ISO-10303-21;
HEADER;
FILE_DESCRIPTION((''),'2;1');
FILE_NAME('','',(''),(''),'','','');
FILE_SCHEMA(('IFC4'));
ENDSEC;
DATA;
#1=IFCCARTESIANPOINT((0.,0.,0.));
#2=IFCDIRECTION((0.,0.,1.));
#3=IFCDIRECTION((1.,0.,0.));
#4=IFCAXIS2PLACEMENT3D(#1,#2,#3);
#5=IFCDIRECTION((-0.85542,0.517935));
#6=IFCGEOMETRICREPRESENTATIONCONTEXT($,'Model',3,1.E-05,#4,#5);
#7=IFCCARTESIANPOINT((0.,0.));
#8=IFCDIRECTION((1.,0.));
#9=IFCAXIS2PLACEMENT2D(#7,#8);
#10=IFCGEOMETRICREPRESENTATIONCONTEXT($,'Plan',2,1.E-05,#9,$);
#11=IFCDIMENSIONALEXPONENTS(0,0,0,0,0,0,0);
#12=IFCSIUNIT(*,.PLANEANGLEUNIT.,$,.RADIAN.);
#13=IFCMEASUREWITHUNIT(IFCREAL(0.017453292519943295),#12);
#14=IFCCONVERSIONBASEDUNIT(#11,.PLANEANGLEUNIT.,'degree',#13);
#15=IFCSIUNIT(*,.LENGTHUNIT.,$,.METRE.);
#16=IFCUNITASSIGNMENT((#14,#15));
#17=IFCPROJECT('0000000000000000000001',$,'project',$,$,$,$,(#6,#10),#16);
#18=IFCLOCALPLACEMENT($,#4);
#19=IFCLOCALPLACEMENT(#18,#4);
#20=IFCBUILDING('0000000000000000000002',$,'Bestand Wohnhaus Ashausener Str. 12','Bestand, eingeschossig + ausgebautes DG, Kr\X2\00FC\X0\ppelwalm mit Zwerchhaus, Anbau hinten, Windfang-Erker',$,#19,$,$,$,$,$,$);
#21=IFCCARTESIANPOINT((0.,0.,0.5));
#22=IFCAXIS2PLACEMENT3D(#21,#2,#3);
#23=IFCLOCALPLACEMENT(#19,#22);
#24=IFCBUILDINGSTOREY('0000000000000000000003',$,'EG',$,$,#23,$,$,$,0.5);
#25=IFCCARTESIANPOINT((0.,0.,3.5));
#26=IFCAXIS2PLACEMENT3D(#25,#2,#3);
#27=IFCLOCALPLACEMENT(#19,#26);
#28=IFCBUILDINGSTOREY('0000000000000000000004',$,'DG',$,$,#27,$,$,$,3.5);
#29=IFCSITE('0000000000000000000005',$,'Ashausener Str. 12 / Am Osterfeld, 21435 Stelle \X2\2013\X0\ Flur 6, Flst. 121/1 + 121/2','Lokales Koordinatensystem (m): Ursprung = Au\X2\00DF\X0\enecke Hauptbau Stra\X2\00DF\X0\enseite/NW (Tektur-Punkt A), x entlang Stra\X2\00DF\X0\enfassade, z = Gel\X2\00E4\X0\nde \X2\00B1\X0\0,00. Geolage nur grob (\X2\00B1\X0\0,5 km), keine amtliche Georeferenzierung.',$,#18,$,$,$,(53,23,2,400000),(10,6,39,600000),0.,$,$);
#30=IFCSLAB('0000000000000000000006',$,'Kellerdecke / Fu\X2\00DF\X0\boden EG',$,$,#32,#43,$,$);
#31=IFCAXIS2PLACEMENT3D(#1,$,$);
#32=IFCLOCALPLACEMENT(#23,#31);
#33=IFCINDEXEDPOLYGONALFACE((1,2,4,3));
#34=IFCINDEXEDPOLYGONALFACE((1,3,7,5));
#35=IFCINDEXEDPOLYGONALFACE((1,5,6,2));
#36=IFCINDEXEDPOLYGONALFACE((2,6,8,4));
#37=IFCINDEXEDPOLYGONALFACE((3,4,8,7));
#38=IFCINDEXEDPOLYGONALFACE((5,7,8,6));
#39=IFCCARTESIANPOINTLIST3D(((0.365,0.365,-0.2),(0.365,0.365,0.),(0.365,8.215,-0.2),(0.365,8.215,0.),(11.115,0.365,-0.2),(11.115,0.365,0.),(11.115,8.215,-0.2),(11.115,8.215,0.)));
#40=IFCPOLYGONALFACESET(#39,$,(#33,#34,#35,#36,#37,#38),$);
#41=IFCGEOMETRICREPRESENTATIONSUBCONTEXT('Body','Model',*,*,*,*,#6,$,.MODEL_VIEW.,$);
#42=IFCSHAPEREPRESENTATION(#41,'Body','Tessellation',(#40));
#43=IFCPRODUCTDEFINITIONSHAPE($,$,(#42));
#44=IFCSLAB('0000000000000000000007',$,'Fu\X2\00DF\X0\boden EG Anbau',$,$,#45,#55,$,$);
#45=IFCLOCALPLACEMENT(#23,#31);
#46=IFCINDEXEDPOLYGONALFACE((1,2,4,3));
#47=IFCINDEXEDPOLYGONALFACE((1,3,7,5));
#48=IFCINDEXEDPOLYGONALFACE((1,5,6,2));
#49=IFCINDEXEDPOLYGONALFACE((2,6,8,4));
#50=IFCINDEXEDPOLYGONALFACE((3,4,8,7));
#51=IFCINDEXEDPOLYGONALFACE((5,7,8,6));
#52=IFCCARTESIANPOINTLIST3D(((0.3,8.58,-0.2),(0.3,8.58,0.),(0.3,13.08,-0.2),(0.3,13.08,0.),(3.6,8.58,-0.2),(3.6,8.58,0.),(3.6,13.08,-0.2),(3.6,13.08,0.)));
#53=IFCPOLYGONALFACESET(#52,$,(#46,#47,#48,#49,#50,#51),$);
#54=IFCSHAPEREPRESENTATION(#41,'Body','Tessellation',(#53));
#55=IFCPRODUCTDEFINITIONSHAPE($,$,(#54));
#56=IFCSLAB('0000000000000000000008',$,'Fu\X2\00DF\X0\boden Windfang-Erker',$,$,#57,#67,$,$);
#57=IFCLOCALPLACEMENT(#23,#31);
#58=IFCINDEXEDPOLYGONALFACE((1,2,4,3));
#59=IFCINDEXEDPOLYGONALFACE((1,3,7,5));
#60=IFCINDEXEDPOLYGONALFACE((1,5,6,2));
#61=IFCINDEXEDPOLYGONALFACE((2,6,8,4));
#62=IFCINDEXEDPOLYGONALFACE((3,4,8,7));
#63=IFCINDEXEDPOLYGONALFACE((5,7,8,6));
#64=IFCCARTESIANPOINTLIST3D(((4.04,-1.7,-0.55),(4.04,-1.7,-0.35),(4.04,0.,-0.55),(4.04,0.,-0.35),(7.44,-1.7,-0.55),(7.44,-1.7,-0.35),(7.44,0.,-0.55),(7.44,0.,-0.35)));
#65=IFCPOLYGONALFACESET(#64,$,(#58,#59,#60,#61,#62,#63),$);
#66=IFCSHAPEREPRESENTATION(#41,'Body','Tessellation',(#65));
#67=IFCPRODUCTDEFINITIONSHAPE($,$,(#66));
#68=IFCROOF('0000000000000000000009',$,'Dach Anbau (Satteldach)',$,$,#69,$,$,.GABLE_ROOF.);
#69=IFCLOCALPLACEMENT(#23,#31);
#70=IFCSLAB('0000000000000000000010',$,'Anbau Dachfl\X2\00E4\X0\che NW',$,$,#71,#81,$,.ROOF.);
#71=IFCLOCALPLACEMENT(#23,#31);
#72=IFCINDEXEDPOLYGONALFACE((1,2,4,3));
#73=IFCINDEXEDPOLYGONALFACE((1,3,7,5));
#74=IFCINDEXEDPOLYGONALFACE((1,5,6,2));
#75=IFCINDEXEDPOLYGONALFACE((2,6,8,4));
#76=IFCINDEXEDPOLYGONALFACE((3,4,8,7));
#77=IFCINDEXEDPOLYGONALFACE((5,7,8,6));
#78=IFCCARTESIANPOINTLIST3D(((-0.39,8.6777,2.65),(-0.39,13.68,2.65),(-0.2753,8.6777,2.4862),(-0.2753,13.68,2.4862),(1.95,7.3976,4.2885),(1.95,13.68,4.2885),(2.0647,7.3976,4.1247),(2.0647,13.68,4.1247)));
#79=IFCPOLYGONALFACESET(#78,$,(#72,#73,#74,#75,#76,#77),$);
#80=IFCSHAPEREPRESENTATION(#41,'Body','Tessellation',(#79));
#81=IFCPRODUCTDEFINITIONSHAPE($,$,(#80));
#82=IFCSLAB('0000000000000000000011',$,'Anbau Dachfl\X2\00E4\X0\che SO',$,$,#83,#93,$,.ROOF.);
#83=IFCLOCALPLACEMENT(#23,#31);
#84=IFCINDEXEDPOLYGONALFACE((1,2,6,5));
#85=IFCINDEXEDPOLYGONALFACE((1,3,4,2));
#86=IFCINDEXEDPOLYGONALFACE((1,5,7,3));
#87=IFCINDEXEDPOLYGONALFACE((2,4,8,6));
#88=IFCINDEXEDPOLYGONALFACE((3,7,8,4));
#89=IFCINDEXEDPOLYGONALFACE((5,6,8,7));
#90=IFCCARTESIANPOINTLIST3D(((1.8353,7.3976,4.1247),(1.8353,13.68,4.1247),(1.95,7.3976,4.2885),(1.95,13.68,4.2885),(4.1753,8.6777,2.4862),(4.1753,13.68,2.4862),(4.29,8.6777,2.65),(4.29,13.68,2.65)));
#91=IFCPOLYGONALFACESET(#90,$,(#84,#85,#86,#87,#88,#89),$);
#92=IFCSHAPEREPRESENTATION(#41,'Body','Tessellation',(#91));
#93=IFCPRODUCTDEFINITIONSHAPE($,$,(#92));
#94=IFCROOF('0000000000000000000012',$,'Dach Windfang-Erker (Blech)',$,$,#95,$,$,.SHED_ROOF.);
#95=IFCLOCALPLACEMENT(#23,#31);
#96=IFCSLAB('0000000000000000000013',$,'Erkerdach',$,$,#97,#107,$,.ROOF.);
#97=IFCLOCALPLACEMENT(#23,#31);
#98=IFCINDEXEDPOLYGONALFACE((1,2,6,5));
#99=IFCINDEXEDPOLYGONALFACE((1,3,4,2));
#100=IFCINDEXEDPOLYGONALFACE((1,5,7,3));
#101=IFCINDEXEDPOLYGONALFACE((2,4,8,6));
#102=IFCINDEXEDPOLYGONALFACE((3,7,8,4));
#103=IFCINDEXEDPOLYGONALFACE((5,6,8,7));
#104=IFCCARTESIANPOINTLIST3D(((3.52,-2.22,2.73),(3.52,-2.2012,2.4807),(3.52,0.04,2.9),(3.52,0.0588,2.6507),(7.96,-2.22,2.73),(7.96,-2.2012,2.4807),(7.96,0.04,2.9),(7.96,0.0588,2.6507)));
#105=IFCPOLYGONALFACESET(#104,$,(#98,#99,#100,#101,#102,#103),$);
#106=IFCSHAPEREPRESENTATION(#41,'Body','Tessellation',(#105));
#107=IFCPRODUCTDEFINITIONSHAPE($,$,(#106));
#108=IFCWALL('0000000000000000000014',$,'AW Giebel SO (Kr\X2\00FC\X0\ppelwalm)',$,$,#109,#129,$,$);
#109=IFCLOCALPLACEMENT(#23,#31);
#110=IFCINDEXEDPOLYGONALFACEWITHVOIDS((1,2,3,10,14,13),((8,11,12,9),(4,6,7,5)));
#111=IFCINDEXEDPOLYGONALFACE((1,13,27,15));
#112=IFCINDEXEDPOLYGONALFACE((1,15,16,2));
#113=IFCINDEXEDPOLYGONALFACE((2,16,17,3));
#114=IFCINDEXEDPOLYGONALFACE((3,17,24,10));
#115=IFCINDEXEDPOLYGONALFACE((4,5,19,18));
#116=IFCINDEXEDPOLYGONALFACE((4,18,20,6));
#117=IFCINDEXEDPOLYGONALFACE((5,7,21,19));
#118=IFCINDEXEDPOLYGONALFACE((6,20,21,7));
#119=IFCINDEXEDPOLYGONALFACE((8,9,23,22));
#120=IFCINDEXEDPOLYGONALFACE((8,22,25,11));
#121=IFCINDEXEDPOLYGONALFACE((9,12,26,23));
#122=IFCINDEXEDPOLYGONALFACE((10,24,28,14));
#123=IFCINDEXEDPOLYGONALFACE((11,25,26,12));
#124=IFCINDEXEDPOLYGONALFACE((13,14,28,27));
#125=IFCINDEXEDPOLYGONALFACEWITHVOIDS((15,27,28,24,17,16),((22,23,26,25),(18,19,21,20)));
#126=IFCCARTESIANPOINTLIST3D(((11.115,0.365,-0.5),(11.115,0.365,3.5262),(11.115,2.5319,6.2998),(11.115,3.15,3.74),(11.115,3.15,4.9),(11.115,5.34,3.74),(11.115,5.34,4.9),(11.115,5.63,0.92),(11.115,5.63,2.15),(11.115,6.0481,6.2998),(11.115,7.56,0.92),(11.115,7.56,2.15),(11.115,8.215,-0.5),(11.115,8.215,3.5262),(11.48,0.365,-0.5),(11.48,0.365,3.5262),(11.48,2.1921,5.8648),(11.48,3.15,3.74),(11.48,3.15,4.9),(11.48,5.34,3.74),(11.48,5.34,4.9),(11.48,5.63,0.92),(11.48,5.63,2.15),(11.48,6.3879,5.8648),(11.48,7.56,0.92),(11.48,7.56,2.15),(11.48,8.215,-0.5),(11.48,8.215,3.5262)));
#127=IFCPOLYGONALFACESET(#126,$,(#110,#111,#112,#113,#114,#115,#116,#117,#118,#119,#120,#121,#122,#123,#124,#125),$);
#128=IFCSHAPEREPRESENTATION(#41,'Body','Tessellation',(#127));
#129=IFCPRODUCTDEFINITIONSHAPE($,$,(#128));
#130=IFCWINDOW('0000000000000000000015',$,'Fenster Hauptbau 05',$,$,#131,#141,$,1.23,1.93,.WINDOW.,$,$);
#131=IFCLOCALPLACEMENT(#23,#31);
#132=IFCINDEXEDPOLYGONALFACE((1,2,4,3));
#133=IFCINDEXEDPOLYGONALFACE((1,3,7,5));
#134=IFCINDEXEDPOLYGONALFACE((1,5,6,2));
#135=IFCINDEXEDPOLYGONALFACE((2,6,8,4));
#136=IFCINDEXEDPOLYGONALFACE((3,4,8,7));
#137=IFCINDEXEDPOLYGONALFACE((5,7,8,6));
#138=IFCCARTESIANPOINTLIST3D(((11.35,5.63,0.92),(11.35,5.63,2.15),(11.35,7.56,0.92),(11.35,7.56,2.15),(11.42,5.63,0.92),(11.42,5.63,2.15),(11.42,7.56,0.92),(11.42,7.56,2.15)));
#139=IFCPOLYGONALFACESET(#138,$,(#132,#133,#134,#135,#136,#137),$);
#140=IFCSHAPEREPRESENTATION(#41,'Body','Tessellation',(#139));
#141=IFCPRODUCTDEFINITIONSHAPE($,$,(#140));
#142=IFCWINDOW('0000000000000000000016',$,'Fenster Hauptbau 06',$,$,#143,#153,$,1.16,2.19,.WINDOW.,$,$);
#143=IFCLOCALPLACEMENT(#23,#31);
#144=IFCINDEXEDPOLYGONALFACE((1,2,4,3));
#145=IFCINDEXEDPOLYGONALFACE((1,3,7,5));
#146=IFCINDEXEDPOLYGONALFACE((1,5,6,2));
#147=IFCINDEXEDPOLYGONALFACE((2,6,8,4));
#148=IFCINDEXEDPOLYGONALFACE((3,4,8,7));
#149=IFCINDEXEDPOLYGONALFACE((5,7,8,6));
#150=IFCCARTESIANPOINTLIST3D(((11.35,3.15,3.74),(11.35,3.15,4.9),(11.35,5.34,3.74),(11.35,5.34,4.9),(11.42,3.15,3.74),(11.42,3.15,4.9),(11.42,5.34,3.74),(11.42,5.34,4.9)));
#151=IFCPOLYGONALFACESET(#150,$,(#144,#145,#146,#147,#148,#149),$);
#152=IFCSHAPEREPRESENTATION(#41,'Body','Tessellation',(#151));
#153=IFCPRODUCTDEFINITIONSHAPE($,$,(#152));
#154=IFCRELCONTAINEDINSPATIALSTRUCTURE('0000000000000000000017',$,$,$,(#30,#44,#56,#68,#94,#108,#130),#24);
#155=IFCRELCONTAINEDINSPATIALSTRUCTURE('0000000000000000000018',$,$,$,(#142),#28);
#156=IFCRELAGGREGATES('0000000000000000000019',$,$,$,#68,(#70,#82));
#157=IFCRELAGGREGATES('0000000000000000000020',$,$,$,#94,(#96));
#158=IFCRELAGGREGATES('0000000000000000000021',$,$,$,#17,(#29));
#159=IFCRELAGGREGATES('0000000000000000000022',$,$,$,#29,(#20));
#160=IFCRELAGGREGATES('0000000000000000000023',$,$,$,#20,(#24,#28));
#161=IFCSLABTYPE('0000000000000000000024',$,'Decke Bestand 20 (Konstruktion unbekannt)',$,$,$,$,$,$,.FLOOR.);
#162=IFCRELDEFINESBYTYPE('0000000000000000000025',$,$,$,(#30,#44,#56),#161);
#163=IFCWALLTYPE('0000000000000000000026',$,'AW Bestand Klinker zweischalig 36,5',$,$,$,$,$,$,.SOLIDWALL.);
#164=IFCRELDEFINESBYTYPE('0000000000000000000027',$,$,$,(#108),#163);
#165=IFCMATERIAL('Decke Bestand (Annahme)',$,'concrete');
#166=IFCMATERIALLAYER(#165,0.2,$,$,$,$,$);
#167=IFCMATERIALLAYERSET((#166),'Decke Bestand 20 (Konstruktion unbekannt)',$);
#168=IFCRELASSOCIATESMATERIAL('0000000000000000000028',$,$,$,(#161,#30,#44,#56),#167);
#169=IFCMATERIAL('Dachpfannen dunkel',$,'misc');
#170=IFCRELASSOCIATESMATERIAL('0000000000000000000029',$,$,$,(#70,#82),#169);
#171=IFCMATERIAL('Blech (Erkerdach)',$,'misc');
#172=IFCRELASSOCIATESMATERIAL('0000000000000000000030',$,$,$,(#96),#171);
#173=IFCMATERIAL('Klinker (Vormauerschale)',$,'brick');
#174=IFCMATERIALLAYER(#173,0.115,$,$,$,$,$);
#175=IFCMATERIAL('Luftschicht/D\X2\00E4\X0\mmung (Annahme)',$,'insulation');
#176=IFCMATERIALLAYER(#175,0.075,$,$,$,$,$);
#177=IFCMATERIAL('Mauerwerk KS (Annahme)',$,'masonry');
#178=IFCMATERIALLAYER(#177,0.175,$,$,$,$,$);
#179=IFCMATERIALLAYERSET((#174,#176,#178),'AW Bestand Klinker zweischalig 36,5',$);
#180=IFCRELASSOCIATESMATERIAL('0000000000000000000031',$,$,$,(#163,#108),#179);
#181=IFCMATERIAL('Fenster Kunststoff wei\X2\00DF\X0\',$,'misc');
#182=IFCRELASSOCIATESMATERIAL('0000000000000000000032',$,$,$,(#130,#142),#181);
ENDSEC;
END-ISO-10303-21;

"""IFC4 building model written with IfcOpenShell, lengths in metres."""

from ifc_helpers import new_model, entity, si_unit, converted_unit, direction, frame, origin_with_axes, origin_2d_with_axis, place, context, subcontext, project, spatial, polyline, indexed_curve, outline, extrude, clip, halfspace, material, layer, layer_set, layer_usage, type_object, element, fill, aggregate, save


model = new_model("IFC4")

# Units and contexts
model_context = context("Model", 3, precision=1e-05, world=origin_with_axes(), true_north=direction((-0.85542, 0.517935)))
plan_context = context("Plan", 2, precision=1e-05, world=origin_2d_with_axis())
body_context = subcontext(model_context, "Body", "Model", "MODEL_VIEW")
ifc_project = project(units=[converted_unit("PLANEANGLEUNIT", "degree", entity("IfcReal", 0.017453292519943295), si_unit("PLANEANGLEUNIT", "RADIAN"), dimensions=[0, 0, 0, 0, 0, 0, 0]), si_unit("LENGTHUNIT", "METRE")], contexts=[model_context, plan_context])

# Site, building, storey
site_placement = place(None, origin_with_axes())
site = spatial("IfcSite", under=ifc_project, at=site_placement, Name="Ashausener Str. 12 / Am Osterfeld, 21435 Stelle – Flur 6, Flst. 121/1 + 121/2", Description="Lokales Koordinatensystem (m): Ursprung = Außenecke Hauptbau Straßenseite/NW (Tektur-Punkt A), x entlang Straßenfassade, z = Gelände ±0,00. Geolage nur grob (±0,5 km), keine amtliche Georeferenzierung.", RefLatitude=(53, 23, 2, 400000), RefLongitude=(10, 6, 39, 600000), RefElevation=0.0)
building_placement = place(site_placement, origin_with_axes())
building = spatial("IfcBuilding", under=site, at=building_placement, Name="Bestand Wohnhaus Ashausener Str. 12", Description="Bestand, eingeschossig + ausgebautes DG, Krüppelwalm mit Zwerchhaus, Anbau hinten, Windfang-Erker")
storey_1_placement = place(building_placement, frame((0.0, 0.0, 0.5), z_axis=(0.0, 0.0, 1.0), x_axis=(1.0, 0.0, 0.0)))
storey_1 = spatial("IfcBuildingStorey", under=building, at=storey_1_placement, Name="EG", Elevation=0.5)

# Slabs
ifc_material_1 = material(Name="Decke Bestand (Annahme)", Category="concrete")
ifc_layer_1 = layer(ifc_material_1, 0.2)
ifc_layer_set_1 = layer_set([ifc_layer_1], Name="Decke Bestand 20 (Konstruktion unbekannt)")
ifc_layer_usage_1 = layer_usage(ifc_layer_set_1, "AXIS3", "POSITIVE", 0.0)
slab_type = type_object("IfcSlabType", Name="Decke Bestand 20 (Konstruktion unbekannt)", PredefinedType="FLOOR", material=ifc_layer_set_1)
slab_1_placement = place(storey_1_placement, frame((0.0, 0.0, -0.5), z_axis=(0.0, 0.0, 1.0), x_axis=(1.0, 0.0, 0.0)))
element("IfcSlab", 1, at=slab_1_placement, inside=storey_1, type_object=slab_type, material=ifc_layer_usage_1, Name="Kellerdecke / Fußboden EG", context=body_context, shape_type="SweptSolid", body=[
    extrude(outline(polyline([(0.365, 0.365), (11.115, 0.365), (11.115, 8.215), (0.365, 8.215), (0.365, 0.365)])), frame((0.0, 0.0, 0.3)), (0.0, 0.0, 1.0), 0.2),
])
ifc_layer_usage_2 = layer_usage(ifc_layer_set_1, "AXIS3", "POSITIVE", 0.0)
slab_2_placement = place(storey_1_placement, frame((0.0, 0.0, -0.5), z_axis=(0.0, 0.0, 1.0), x_axis=(1.0, 0.0, 0.0)))
element("IfcSlab", 2, at=slab_2_placement, inside=storey_1, type_object=slab_type, material=ifc_layer_usage_2, Name="Fußboden EG Anbau", context=body_context, shape_type="SweptSolid", body=[
    extrude(outline(polyline([(0.3, 8.58), (3.6, 8.58), (3.6, 13.08), (0.3, 13.08), (0.3, 8.58)])), frame((0.0, 0.0, 0.3)), (0.0, 0.0, 1.0), 0.2),
])
ifc_layer_usage_3 = layer_usage(ifc_layer_set_1, "AXIS3", "POSITIVE", 0.0)
slab_3_placement = place(storey_1_placement, frame((0.0, 0.0, -0.5), z_axis=(0.0, 0.0, 1.0), x_axis=(1.0, 0.0, 0.0)))
element("IfcSlab", 3, at=slab_3_placement, inside=storey_1, type_object=slab_type, material=ifc_layer_usage_3, Name="Fußboden Windfang-Erker", context=body_context, shape_type="SweptSolid", body=[
    extrude(outline(polyline([(4.04, -1.7), (7.44, -1.7), (7.44, 0.0), (4.04, 0.0), (4.04, -1.7)])), frame((0.0, 0.0, -0.05)), (0.0, 0.0, 1.0), 0.2),
])

# Roof, slabs
roof_1_placement = place(storey_1_placement, frame((0.0, 0.0, -0.5), z_axis=(0.0, 0.0, 1.0), x_axis=(1.0, 0.0, 0.0)))
roof_1 = element("IfcRoof", 4, at=roof_1_placement, inside=storey_1, Name="Dach Anbau (Satteldach)", PredefinedType="GABLE_ROOF")
ifc_material_2 = material(Name="Dachpfannen dunkel", Category="misc")
slab_4_placement = place(roof_1_placement, origin_with_axes())
slab_4 = element("IfcSlab", 5, at=slab_4_placement, material=ifc_material_2, Name="Anbau Dachfläche NW", PredefinedType="ROOF", context=body_context, shape_type="SweptSolid", body=[
    extrude(outline(polyline([(0.0, 0.0), (2.8566, 0.0), (2.8566, -6.2824), (0.0, -5.0023), (0.0, 0.0)])), frame((-0.39, 13.68, 3.15), z_axis=(-0.573577, 0.0, 0.819151), x_axis=(0.819151, 0.0, 0.573577)), (0.0, 0.0, -1.0), 0.2),
])
slab_5_placement = place(roof_1_placement, origin_with_axes())
slab_5 = element("IfcSlab", 6, at=slab_5_placement, material=ifc_material_2, Name="Anbau Dachfläche SO", PredefinedType="ROOF", context=body_context, shape_type="SweptSolid", body=[
    extrude(outline(polyline([(0.0, 0.0), (2.8566, 0.0), (2.8566, -5.0023), (0.0, -6.2824), (0.0, 0.0)])), frame((1.95, 13.68, 4.7885), z_axis=(0.573577, 0.0, 0.819151), x_axis=(0.819151, 0.0, -0.573577)), (0.0, 0.0, -1.0), 0.2),
])
aggregate(roof_1, [slab_4, slab_5])

# Roof, slab
roof_2_placement = place(storey_1_placement, frame((0.0, 0.0, -0.5), z_axis=(0.0, 0.0, 1.0), x_axis=(1.0, 0.0, 0.0)))
roof_2 = element("IfcRoof", 7, at=roof_2_placement, inside=storey_1, Name="Dach Windfang-Erker (Blech)", PredefinedType="SHED_ROOF")
ifc_material_3 = material(Name="Blech (Erkerdach)", Category="misc")
slab_6_placement = place(roof_2_placement, origin_with_axes())
slab_6 = element("IfcSlab", 8, at=slab_6_placement, material=ifc_material_3, Name="Erkerdach", PredefinedType="ROOF", context=body_context, shape_type="SweptSolid", body=[
    extrude(outline(polyline([(0.0, 0.0), (4.44, 0.0), (4.44, 2.2664), (0.0, 2.2664), (0.0, 0.0)])), frame((3.52, -2.22, 3.23), z_axis=(0.0, -0.075009, 0.997183), x_axis=(1.0, 0.0, 0.0)), (0.0, 0.0, -1.0), 0.25),
])
aggregate(roof_2, [slab_6])

# Shared definitions
ifc_material_4 = material(Name="Klinker (Vormauerschale)", Category="brick")
ifc_layer_2 = layer(ifc_material_4, 0.115)
ifc_material_5 = material(Name="Luftschicht/Dämmung (Annahme)", Category="insulation")
ifc_layer_3 = layer(ifc_material_5, 0.075)
ifc_material_6 = material(Name="Mauerwerk KS (Annahme)", Category="masonry")
ifc_layer_4 = layer(ifc_material_6, 0.175)
ifc_layer_set_2 = layer_set([ifc_layer_2, ifc_layer_3, ifc_layer_4], Name="AW Bestand Klinker zweischalig 36,5")
wall_type_1 = type_object("IfcWallType", Name="AW Bestand Klinker zweischalig 36,5", PredefinedType="SOLIDWALL", material=ifc_layer_set_2)
ifc_material_7 = material(Name="Fenster Kunststoff weiß", Category="misc")

# Shared definitions
storey_2_placement = place(building_placement, frame((0.0, 0.0, 3.5), z_axis=(0.0, 0.0, 1.0), x_axis=(1.0, 0.0, 0.0)))
storey_2 = spatial("IfcBuildingStorey", under=building, at=storey_2_placement, Name="DG", Elevation=3.5)

# Wall, openings, windows
ifc_layer_usage_4 = layer_usage(ifc_layer_set_2, "AXIS2", "POSITIVE", 0.0)
wall_1_placement = place(storey_1_placement, frame((11.48, 0.365, -0.5), z_axis=(0.0, 0.0, 1.0), x_axis=(0.0, 1.0, 0.0)))
wall_1 = element("IfcWall", 9, at=wall_1_placement, inside=storey_1, type_object=wall_type_1, material=ifc_layer_usage_4, Name="AW Giebel SO (Krüppelwalm)", context=body_context, shape_type="Clipping", body=[
    clip(clip(clip(clip(extrude(outline(indexed_curve([(0.0, 0.0), (0.0, 0.365), (7.85, 0.365), (7.85, 0.0), (0.0, 0.0)], self_intersect=False)), origin_with_axes(), (0.0, 0.0, 1.0), 12.0), halfspace(frame((-0.365, -0.39, 5.9), z_axis=(0.0, -0.76604, 0.64279), x_axis=(-1.0, 0.0, 0.0)), False)), halfspace(frame((-0.365, 11.87, 5.9), z_axis=(0.0, 0.76604, 0.64279), x_axis=(1.0, 0.0, 0.0)), False)), halfspace(frame((3.925, 11.48, 9.05), z_axis=(0.78801, 0.0, 0.61566), x_axis=(0.0, -1.0, 0.0)), False)), halfspace(frame((3.925, 11.48, 9.05), z_axis=(-0.78801, 0.0, 0.61566), x_axis=(0.0, 1.0, 0.0)), False)),
])
opening_1_placement = place(wall_1_placement, frame((5.265, -0.1, 1.42), z_axis=(0.0, 0.0, 1.0), x_axis=(1.0, 0.0, 0.0)))
opening_1 = element("IfcOpeningElement", 10, at=opening_1_placement, cuts=wall_1, context=body_context, shape_type="SweptSolid", body=[
    extrude(outline(indexed_curve([(0.0, 0.0), (0.0, 0.565), (1.93, 0.565), (1.93, 0.0), (0.0, 0.0)], self_intersect=False)), origin_with_axes(), (0.0, 0.0, 1.0), 1.23),
])
opening_2_placement = place(wall_1_placement, frame((2.785, -0.1, 4.24), z_axis=(0.0, 0.0, 1.0), x_axis=(1.0, 0.0, 0.0)))
opening_2 = element("IfcOpeningElement", 11, at=opening_2_placement, cuts=wall_1, context=body_context, shape_type="SweptSolid", body=[
    extrude(outline(indexed_curve([(0.0, 0.0), (0.0, 0.565), (2.19, 0.565), (2.19, 0.0), (0.0, 0.0)], self_intersect=False)), origin_with_axes(), (0.0, 0.0, 1.0), 1.16),
])
window_1_placement = place(storey_1_placement, frame((11.42, 5.63, 0.92), z_axis=(0.0, 0.0, 1.0), x_axis=(0.0, 1.0, 0.0)))
window_1 = element("IfcWindow", 12, at=window_1_placement, inside=storey_1, material=ifc_material_7, Name="Fenster Hauptbau 05", OverallHeight=1.23, OverallWidth=1.93, PredefinedType="WINDOW", context=body_context, shape_type="SweptSolid", body=[
    extrude(outline(indexed_curve([(0.0, 0.0), (0.0, 0.07), (1.93, 0.07), (1.93, 0.0), (0.0, 0.0)], self_intersect=False)), origin_with_axes(), (0.0, 0.0, 1.0), 1.23),
])
fill(opening_1, window_1)
window_2_placement = place(storey_2_placement, frame((11.42, 3.15, 0.74), z_axis=(0.0, 0.0, 1.0), x_axis=(0.0, 1.0, 0.0)))
window_2 = element("IfcWindow", 13, at=window_2_placement, inside=storey_2, material=ifc_material_7, Name="Fenster Hauptbau 06", OverallHeight=1.16, OverallWidth=2.19, PredefinedType="WINDOW", context=body_context, shape_type="SweptSolid", body=[
    extrude(outline(indexed_curve([(0.0, 0.0), (0.0, 0.07), (2.19, 0.07), (2.19, 0.0), (0.0, 0.0)], self_intersect=False)), origin_with_axes(), (0.0, 0.0, 1.0), 1.16),
])
fill(opening_2, window_2)

save(model, "model.ifc")
